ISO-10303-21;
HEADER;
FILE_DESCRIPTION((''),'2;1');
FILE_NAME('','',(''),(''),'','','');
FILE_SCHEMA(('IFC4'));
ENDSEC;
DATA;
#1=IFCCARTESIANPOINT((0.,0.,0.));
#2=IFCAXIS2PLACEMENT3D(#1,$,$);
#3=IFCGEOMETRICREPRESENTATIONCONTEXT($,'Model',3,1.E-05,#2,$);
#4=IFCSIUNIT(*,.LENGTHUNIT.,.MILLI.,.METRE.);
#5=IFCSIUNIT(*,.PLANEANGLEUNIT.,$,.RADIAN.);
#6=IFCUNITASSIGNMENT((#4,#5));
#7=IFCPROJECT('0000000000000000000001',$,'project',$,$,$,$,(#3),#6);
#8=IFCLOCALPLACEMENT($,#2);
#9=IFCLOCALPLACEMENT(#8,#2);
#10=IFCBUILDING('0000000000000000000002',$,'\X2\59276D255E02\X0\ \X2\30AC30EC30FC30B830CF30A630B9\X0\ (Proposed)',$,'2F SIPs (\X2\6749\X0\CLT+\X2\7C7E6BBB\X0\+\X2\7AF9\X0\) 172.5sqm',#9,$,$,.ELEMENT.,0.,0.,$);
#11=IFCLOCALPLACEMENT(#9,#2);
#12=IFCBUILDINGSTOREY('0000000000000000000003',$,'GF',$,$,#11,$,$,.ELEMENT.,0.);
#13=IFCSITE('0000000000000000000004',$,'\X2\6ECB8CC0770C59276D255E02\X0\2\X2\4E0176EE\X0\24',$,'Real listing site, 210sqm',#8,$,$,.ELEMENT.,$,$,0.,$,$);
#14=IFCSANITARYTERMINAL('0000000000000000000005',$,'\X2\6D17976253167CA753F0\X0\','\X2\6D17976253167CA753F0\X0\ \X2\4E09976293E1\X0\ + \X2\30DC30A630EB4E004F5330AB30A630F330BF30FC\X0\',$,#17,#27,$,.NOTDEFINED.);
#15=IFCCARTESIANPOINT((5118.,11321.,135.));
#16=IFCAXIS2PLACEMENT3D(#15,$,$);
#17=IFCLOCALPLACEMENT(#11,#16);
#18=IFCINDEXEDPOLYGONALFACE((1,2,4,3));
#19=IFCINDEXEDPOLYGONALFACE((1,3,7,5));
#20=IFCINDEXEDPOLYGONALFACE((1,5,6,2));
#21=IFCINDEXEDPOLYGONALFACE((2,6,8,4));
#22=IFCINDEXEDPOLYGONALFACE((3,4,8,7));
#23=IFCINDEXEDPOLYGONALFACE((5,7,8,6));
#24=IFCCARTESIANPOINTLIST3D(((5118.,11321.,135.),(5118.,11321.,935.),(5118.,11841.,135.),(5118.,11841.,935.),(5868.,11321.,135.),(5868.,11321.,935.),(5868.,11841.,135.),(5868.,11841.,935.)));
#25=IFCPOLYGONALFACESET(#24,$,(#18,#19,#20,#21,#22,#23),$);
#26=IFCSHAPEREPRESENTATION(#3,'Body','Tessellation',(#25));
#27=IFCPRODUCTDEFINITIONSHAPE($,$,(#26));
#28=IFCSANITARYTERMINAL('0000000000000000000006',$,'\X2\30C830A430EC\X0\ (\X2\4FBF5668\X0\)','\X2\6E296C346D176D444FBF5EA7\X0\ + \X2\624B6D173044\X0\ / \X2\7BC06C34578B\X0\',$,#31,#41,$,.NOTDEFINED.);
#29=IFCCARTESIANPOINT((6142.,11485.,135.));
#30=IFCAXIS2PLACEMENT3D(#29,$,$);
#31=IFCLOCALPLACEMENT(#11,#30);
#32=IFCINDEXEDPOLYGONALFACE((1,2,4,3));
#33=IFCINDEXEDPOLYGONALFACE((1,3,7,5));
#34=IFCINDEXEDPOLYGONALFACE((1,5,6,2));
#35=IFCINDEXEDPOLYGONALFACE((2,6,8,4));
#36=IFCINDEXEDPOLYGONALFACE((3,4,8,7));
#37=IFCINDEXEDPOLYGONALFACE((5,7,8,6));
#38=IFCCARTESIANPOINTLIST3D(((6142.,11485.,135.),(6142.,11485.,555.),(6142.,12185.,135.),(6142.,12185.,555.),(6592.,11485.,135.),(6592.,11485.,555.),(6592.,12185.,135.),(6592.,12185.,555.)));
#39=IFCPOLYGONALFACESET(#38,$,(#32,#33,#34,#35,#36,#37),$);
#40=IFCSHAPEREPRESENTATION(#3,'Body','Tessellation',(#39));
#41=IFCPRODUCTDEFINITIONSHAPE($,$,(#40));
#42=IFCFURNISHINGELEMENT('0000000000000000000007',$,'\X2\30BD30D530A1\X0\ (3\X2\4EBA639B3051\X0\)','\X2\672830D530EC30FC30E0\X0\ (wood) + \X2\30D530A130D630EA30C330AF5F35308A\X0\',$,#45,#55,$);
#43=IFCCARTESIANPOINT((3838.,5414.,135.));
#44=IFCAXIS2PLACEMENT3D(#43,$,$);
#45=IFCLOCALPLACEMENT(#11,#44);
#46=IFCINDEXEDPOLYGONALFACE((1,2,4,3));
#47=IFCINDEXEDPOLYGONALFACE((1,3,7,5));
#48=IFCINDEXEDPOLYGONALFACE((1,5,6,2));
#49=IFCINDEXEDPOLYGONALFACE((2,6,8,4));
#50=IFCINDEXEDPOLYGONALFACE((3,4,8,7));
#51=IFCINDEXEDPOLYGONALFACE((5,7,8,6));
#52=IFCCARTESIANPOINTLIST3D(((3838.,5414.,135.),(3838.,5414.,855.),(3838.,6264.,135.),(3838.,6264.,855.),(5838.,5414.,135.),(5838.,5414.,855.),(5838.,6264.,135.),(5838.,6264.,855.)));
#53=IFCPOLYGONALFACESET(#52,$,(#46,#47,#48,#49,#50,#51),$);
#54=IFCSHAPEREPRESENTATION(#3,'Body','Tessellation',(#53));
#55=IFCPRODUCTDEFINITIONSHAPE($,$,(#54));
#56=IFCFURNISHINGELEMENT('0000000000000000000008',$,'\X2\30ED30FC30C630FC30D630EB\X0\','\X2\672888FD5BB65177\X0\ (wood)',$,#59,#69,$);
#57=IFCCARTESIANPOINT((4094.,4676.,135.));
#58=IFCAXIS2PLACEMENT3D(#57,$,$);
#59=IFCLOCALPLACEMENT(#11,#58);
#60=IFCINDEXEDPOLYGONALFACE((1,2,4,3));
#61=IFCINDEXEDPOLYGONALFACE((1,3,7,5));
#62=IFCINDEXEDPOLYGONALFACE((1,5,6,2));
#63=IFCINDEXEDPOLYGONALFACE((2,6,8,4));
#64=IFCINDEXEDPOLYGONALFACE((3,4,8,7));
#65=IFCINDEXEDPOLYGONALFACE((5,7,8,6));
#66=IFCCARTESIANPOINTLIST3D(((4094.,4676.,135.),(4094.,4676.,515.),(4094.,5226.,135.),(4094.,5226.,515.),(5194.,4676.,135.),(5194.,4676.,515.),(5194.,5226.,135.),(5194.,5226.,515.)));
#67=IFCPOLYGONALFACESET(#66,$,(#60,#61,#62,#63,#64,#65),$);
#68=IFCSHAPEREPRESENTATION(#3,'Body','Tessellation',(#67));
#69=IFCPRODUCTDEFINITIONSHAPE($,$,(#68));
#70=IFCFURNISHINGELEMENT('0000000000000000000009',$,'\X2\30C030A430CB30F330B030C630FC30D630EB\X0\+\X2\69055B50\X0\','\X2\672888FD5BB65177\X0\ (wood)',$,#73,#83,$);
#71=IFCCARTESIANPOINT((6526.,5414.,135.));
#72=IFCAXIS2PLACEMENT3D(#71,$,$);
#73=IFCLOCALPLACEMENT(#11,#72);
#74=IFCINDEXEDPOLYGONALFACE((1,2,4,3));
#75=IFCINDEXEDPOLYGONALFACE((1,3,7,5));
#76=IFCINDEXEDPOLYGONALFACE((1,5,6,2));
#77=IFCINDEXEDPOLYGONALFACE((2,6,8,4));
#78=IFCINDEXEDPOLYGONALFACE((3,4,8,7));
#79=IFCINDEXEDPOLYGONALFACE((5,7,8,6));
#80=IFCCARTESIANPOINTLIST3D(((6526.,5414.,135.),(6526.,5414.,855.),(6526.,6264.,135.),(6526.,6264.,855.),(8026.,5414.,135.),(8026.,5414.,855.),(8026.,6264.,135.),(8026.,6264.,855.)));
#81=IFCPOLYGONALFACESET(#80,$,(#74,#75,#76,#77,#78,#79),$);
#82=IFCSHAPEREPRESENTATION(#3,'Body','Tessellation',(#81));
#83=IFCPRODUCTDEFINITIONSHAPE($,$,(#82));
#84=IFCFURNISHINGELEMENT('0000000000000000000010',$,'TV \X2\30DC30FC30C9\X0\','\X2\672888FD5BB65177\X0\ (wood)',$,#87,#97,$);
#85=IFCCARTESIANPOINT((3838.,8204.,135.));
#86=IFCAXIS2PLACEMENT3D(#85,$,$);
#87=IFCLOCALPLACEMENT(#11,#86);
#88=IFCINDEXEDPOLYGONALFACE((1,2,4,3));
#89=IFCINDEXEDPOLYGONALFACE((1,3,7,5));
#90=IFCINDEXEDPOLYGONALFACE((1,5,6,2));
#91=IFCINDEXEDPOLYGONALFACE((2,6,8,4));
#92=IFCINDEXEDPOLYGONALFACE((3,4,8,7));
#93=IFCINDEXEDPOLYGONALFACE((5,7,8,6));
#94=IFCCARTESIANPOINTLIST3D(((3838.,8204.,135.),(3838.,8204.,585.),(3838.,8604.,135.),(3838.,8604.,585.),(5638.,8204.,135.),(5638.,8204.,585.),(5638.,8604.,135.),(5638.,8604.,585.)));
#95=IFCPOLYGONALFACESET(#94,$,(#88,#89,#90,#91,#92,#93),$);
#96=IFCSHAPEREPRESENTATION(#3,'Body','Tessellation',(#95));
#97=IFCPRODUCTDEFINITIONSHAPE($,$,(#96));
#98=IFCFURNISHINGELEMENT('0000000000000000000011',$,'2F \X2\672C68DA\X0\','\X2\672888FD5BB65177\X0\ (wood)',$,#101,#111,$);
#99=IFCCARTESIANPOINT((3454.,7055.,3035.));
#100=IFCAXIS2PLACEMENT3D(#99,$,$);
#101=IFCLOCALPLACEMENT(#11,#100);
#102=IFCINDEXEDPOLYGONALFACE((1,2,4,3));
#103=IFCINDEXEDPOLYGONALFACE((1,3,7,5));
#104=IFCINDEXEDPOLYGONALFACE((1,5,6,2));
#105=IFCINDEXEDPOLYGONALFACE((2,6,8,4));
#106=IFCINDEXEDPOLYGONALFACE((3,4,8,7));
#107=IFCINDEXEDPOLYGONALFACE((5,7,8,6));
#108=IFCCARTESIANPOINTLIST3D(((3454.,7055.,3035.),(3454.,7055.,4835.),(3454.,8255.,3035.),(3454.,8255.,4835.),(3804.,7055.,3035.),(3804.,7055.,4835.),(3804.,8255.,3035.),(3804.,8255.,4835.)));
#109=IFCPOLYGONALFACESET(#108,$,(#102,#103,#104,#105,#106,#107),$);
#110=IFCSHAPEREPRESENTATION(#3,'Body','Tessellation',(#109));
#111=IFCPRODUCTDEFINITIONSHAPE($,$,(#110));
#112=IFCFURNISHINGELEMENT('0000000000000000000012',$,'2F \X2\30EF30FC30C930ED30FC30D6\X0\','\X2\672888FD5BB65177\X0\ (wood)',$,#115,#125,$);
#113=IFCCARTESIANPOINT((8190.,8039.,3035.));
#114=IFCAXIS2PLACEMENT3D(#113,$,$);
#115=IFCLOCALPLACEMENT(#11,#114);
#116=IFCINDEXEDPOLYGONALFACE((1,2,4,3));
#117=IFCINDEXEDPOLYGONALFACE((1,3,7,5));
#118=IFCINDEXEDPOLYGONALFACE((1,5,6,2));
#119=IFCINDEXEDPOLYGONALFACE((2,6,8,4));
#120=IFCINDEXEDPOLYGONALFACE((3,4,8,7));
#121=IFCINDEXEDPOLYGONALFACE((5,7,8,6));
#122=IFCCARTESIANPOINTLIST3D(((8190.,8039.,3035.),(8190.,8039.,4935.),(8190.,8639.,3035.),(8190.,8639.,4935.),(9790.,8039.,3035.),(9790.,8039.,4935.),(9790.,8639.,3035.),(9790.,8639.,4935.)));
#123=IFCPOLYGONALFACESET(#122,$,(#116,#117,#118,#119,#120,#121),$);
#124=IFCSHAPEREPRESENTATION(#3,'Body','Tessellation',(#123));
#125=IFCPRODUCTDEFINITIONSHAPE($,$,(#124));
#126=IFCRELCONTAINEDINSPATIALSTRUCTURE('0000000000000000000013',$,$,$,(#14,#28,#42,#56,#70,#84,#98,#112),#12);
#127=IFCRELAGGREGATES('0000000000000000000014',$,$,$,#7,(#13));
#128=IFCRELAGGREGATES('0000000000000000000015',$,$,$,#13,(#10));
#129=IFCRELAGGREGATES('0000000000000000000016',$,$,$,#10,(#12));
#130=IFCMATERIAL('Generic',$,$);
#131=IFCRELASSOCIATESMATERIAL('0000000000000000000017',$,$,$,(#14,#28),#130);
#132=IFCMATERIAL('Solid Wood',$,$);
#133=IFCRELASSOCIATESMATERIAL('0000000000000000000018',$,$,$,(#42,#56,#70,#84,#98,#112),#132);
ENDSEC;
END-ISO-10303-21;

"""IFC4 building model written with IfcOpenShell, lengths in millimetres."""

from ifc_helpers import new_model, si_unit, frame, frame_2d, origin, place, context, project, spatial, rectangle, extrude, material, element, save


model = new_model("IFC4")

# Units and contexts
model_context = context("Model", 3, precision=1e-05, world=origin())
ifc_project = project(units=[si_unit("LENGTHUNIT", "METRE", prefix="MILLI"), si_unit("PLANEANGLEUNIT", "RADIAN")], contexts=[model_context])

# Site, building, storey
site_placement = place(None, origin())
site = spatial("IfcSite", under=ifc_project, at=site_placement, Name="滋賀県大津市2丁目24", ObjectType="Real listing site, 210sqm", CompositionType="ELEMENT", RefElevation=0.0)
building_placement = place(site_placement, origin())
building = spatial("IfcBuilding", under=site, at=building_placement, Name="大津市 ガレージハウス (Proposed)", ObjectType="2F SIPs (杉CLT+籾殻+竹) 172.5sqm", CompositionType="ELEMENT", ElevationOfRefHeight=0.0, ElevationOfTerrain=0.0)
storey_placement = place(building_placement, origin())
storey = spatial("IfcBuildingStorey", under=building, at=storey_placement, Name="GF", CompositionType="ELEMENT", Elevation=0.0)

# Shared definitions
ifc_material_1 = material(Name="Generic")

# Shared definitions
ifc_material_2 = material(Name="Solid Wood")

# Sanitary terminals
sanitary_terminal_1_placement = place(storey_placement, frame((5118.0, 11321.0, 135.0)))
element("IfcSanitaryTerminal", 1, at=sanitary_terminal_1_placement, inside=storey, material=ifc_material_1, Name="洗面化粧台", Description="洗面化粧台 三面鏡 + ボウル一体カウンター", PredefinedType="NOTDEFINED", context=model_context, shape_type="SweptSolid", body=[
    extrude(rectangle(XDim=750.0, YDim=520.0, at=frame_2d((375.0, 260.0))), frame((5118.0, 11321.0, 135.0)), (0.0, 0.0, 1.0), 800.0),
])
sanitary_terminal_2_placement = place(storey_placement, frame((6142.0, 11485.0, 135.0)))
element("IfcSanitaryTerminal", 2, at=sanitary_terminal_2_placement, inside=storey, material=ifc_material_1, Name="トイレ (便器)", Description="温水洗浄便座 + 手洗い / 節水型", PredefinedType="NOTDEFINED", context=model_context, shape_type="SweptSolid", body=[
    extrude(rectangle(XDim=450.0, YDim=700.0, at=frame_2d((225.0, 350.0))), frame((6142.0, 11485.0, 135.0)), (0.0, 0.0, 1.0), 420.0),
])

# Furnishing elements
furnishing_1_placement = place(storey_placement, frame((3838.0, 5414.0, 135.0)))
element("IfcFurnishingElement", 3, at=furnishing_1_placement, inside=storey, material=ifc_material_2, Name="ソファ (3人掛け)", Description="木フレーム (wood) + ファブリック張り", context=model_context, shape_type="SweptSolid", body=[
    extrude(rectangle(XDim=2000.0, YDim=850.0, at=frame_2d((1000.0, 425.0))), frame((3838.0, 5414.0, 135.0)), (0.0, 0.0, 1.0), 720.0),
])
furnishing_2_placement = place(storey_placement, frame((4094.0, 4676.0, 135.0)))
element("IfcFurnishingElement", 4, at=furnishing_2_placement, inside=storey, material=ifc_material_2, Name="ローテーブル", Description="木製家具 (wood)", context=model_context, shape_type="SweptSolid", body=[
    extrude(rectangle(XDim=1100.0, YDim=550.0, at=frame_2d((550.0, 275.0))), frame((4094.0, 4676.0, 135.0)), (0.0, 0.0, 1.0), 380.0),
])
furnishing_3_placement = place(storey_placement, frame((6526.0, 5414.0, 135.0)))
element("IfcFurnishingElement", 5, at=furnishing_3_placement, inside=storey, material=ifc_material_2, Name="ダイニングテーブル+椅子", Description="木製家具 (wood)", context=model_context, shape_type="SweptSolid", body=[
    extrude(rectangle(XDim=1500.0, YDim=850.0, at=frame_2d((750.0, 425.0))), frame((6526.0, 5414.0, 135.0)), (0.0, 0.0, 1.0), 720.0),
])
furnishing_4_placement = place(storey_placement, frame((3838.0, 8204.0, 135.0)))
element("IfcFurnishingElement", 6, at=furnishing_4_placement, inside=storey, material=ifc_material_2, Name="TV ボード", Description="木製家具 (wood)", context=model_context, shape_type="SweptSolid", body=[
    extrude(rectangle(XDim=1800.0, YDim=400.0, at=frame_2d((900.0, 200.0))), frame((3838.0, 8204.0, 135.0)), (0.0, 0.0, 1.0), 450.0),
])
furnishing_5_placement = place(storey_placement, frame((3454.0, 7055.0, 3035.0)))
element("IfcFurnishingElement", 7, at=furnishing_5_placement, inside=storey, material=ifc_material_2, Name="2F 本棚", Description="木製家具 (wood)", context=model_context, shape_type="SweptSolid", body=[
    extrude(rectangle(XDim=350.0, YDim=1200.0, at=frame_2d((175.0, 600.0))), frame((3454.0, 7055.0, 3035.0)), (0.0, 0.0, 1.0), 1800.0),
])
furnishing_6_placement = place(storey_placement, frame((8190.0, 8039.0, 3035.0)))
element("IfcFurnishingElement", 8, at=furnishing_6_placement, inside=storey, material=ifc_material_2, Name="2F ワードローブ", Description="木製家具 (wood)", context=model_context, shape_type="SweptSolid", body=[
    extrude(rectangle(XDim=1600.0, YDim=600.0, at=frame_2d((800.0, 300.0))), frame((8190.0, 8039.0, 3035.0)), (0.0, 0.0, 1.0), 1900.0),
])

save(model, "model.ifc")
